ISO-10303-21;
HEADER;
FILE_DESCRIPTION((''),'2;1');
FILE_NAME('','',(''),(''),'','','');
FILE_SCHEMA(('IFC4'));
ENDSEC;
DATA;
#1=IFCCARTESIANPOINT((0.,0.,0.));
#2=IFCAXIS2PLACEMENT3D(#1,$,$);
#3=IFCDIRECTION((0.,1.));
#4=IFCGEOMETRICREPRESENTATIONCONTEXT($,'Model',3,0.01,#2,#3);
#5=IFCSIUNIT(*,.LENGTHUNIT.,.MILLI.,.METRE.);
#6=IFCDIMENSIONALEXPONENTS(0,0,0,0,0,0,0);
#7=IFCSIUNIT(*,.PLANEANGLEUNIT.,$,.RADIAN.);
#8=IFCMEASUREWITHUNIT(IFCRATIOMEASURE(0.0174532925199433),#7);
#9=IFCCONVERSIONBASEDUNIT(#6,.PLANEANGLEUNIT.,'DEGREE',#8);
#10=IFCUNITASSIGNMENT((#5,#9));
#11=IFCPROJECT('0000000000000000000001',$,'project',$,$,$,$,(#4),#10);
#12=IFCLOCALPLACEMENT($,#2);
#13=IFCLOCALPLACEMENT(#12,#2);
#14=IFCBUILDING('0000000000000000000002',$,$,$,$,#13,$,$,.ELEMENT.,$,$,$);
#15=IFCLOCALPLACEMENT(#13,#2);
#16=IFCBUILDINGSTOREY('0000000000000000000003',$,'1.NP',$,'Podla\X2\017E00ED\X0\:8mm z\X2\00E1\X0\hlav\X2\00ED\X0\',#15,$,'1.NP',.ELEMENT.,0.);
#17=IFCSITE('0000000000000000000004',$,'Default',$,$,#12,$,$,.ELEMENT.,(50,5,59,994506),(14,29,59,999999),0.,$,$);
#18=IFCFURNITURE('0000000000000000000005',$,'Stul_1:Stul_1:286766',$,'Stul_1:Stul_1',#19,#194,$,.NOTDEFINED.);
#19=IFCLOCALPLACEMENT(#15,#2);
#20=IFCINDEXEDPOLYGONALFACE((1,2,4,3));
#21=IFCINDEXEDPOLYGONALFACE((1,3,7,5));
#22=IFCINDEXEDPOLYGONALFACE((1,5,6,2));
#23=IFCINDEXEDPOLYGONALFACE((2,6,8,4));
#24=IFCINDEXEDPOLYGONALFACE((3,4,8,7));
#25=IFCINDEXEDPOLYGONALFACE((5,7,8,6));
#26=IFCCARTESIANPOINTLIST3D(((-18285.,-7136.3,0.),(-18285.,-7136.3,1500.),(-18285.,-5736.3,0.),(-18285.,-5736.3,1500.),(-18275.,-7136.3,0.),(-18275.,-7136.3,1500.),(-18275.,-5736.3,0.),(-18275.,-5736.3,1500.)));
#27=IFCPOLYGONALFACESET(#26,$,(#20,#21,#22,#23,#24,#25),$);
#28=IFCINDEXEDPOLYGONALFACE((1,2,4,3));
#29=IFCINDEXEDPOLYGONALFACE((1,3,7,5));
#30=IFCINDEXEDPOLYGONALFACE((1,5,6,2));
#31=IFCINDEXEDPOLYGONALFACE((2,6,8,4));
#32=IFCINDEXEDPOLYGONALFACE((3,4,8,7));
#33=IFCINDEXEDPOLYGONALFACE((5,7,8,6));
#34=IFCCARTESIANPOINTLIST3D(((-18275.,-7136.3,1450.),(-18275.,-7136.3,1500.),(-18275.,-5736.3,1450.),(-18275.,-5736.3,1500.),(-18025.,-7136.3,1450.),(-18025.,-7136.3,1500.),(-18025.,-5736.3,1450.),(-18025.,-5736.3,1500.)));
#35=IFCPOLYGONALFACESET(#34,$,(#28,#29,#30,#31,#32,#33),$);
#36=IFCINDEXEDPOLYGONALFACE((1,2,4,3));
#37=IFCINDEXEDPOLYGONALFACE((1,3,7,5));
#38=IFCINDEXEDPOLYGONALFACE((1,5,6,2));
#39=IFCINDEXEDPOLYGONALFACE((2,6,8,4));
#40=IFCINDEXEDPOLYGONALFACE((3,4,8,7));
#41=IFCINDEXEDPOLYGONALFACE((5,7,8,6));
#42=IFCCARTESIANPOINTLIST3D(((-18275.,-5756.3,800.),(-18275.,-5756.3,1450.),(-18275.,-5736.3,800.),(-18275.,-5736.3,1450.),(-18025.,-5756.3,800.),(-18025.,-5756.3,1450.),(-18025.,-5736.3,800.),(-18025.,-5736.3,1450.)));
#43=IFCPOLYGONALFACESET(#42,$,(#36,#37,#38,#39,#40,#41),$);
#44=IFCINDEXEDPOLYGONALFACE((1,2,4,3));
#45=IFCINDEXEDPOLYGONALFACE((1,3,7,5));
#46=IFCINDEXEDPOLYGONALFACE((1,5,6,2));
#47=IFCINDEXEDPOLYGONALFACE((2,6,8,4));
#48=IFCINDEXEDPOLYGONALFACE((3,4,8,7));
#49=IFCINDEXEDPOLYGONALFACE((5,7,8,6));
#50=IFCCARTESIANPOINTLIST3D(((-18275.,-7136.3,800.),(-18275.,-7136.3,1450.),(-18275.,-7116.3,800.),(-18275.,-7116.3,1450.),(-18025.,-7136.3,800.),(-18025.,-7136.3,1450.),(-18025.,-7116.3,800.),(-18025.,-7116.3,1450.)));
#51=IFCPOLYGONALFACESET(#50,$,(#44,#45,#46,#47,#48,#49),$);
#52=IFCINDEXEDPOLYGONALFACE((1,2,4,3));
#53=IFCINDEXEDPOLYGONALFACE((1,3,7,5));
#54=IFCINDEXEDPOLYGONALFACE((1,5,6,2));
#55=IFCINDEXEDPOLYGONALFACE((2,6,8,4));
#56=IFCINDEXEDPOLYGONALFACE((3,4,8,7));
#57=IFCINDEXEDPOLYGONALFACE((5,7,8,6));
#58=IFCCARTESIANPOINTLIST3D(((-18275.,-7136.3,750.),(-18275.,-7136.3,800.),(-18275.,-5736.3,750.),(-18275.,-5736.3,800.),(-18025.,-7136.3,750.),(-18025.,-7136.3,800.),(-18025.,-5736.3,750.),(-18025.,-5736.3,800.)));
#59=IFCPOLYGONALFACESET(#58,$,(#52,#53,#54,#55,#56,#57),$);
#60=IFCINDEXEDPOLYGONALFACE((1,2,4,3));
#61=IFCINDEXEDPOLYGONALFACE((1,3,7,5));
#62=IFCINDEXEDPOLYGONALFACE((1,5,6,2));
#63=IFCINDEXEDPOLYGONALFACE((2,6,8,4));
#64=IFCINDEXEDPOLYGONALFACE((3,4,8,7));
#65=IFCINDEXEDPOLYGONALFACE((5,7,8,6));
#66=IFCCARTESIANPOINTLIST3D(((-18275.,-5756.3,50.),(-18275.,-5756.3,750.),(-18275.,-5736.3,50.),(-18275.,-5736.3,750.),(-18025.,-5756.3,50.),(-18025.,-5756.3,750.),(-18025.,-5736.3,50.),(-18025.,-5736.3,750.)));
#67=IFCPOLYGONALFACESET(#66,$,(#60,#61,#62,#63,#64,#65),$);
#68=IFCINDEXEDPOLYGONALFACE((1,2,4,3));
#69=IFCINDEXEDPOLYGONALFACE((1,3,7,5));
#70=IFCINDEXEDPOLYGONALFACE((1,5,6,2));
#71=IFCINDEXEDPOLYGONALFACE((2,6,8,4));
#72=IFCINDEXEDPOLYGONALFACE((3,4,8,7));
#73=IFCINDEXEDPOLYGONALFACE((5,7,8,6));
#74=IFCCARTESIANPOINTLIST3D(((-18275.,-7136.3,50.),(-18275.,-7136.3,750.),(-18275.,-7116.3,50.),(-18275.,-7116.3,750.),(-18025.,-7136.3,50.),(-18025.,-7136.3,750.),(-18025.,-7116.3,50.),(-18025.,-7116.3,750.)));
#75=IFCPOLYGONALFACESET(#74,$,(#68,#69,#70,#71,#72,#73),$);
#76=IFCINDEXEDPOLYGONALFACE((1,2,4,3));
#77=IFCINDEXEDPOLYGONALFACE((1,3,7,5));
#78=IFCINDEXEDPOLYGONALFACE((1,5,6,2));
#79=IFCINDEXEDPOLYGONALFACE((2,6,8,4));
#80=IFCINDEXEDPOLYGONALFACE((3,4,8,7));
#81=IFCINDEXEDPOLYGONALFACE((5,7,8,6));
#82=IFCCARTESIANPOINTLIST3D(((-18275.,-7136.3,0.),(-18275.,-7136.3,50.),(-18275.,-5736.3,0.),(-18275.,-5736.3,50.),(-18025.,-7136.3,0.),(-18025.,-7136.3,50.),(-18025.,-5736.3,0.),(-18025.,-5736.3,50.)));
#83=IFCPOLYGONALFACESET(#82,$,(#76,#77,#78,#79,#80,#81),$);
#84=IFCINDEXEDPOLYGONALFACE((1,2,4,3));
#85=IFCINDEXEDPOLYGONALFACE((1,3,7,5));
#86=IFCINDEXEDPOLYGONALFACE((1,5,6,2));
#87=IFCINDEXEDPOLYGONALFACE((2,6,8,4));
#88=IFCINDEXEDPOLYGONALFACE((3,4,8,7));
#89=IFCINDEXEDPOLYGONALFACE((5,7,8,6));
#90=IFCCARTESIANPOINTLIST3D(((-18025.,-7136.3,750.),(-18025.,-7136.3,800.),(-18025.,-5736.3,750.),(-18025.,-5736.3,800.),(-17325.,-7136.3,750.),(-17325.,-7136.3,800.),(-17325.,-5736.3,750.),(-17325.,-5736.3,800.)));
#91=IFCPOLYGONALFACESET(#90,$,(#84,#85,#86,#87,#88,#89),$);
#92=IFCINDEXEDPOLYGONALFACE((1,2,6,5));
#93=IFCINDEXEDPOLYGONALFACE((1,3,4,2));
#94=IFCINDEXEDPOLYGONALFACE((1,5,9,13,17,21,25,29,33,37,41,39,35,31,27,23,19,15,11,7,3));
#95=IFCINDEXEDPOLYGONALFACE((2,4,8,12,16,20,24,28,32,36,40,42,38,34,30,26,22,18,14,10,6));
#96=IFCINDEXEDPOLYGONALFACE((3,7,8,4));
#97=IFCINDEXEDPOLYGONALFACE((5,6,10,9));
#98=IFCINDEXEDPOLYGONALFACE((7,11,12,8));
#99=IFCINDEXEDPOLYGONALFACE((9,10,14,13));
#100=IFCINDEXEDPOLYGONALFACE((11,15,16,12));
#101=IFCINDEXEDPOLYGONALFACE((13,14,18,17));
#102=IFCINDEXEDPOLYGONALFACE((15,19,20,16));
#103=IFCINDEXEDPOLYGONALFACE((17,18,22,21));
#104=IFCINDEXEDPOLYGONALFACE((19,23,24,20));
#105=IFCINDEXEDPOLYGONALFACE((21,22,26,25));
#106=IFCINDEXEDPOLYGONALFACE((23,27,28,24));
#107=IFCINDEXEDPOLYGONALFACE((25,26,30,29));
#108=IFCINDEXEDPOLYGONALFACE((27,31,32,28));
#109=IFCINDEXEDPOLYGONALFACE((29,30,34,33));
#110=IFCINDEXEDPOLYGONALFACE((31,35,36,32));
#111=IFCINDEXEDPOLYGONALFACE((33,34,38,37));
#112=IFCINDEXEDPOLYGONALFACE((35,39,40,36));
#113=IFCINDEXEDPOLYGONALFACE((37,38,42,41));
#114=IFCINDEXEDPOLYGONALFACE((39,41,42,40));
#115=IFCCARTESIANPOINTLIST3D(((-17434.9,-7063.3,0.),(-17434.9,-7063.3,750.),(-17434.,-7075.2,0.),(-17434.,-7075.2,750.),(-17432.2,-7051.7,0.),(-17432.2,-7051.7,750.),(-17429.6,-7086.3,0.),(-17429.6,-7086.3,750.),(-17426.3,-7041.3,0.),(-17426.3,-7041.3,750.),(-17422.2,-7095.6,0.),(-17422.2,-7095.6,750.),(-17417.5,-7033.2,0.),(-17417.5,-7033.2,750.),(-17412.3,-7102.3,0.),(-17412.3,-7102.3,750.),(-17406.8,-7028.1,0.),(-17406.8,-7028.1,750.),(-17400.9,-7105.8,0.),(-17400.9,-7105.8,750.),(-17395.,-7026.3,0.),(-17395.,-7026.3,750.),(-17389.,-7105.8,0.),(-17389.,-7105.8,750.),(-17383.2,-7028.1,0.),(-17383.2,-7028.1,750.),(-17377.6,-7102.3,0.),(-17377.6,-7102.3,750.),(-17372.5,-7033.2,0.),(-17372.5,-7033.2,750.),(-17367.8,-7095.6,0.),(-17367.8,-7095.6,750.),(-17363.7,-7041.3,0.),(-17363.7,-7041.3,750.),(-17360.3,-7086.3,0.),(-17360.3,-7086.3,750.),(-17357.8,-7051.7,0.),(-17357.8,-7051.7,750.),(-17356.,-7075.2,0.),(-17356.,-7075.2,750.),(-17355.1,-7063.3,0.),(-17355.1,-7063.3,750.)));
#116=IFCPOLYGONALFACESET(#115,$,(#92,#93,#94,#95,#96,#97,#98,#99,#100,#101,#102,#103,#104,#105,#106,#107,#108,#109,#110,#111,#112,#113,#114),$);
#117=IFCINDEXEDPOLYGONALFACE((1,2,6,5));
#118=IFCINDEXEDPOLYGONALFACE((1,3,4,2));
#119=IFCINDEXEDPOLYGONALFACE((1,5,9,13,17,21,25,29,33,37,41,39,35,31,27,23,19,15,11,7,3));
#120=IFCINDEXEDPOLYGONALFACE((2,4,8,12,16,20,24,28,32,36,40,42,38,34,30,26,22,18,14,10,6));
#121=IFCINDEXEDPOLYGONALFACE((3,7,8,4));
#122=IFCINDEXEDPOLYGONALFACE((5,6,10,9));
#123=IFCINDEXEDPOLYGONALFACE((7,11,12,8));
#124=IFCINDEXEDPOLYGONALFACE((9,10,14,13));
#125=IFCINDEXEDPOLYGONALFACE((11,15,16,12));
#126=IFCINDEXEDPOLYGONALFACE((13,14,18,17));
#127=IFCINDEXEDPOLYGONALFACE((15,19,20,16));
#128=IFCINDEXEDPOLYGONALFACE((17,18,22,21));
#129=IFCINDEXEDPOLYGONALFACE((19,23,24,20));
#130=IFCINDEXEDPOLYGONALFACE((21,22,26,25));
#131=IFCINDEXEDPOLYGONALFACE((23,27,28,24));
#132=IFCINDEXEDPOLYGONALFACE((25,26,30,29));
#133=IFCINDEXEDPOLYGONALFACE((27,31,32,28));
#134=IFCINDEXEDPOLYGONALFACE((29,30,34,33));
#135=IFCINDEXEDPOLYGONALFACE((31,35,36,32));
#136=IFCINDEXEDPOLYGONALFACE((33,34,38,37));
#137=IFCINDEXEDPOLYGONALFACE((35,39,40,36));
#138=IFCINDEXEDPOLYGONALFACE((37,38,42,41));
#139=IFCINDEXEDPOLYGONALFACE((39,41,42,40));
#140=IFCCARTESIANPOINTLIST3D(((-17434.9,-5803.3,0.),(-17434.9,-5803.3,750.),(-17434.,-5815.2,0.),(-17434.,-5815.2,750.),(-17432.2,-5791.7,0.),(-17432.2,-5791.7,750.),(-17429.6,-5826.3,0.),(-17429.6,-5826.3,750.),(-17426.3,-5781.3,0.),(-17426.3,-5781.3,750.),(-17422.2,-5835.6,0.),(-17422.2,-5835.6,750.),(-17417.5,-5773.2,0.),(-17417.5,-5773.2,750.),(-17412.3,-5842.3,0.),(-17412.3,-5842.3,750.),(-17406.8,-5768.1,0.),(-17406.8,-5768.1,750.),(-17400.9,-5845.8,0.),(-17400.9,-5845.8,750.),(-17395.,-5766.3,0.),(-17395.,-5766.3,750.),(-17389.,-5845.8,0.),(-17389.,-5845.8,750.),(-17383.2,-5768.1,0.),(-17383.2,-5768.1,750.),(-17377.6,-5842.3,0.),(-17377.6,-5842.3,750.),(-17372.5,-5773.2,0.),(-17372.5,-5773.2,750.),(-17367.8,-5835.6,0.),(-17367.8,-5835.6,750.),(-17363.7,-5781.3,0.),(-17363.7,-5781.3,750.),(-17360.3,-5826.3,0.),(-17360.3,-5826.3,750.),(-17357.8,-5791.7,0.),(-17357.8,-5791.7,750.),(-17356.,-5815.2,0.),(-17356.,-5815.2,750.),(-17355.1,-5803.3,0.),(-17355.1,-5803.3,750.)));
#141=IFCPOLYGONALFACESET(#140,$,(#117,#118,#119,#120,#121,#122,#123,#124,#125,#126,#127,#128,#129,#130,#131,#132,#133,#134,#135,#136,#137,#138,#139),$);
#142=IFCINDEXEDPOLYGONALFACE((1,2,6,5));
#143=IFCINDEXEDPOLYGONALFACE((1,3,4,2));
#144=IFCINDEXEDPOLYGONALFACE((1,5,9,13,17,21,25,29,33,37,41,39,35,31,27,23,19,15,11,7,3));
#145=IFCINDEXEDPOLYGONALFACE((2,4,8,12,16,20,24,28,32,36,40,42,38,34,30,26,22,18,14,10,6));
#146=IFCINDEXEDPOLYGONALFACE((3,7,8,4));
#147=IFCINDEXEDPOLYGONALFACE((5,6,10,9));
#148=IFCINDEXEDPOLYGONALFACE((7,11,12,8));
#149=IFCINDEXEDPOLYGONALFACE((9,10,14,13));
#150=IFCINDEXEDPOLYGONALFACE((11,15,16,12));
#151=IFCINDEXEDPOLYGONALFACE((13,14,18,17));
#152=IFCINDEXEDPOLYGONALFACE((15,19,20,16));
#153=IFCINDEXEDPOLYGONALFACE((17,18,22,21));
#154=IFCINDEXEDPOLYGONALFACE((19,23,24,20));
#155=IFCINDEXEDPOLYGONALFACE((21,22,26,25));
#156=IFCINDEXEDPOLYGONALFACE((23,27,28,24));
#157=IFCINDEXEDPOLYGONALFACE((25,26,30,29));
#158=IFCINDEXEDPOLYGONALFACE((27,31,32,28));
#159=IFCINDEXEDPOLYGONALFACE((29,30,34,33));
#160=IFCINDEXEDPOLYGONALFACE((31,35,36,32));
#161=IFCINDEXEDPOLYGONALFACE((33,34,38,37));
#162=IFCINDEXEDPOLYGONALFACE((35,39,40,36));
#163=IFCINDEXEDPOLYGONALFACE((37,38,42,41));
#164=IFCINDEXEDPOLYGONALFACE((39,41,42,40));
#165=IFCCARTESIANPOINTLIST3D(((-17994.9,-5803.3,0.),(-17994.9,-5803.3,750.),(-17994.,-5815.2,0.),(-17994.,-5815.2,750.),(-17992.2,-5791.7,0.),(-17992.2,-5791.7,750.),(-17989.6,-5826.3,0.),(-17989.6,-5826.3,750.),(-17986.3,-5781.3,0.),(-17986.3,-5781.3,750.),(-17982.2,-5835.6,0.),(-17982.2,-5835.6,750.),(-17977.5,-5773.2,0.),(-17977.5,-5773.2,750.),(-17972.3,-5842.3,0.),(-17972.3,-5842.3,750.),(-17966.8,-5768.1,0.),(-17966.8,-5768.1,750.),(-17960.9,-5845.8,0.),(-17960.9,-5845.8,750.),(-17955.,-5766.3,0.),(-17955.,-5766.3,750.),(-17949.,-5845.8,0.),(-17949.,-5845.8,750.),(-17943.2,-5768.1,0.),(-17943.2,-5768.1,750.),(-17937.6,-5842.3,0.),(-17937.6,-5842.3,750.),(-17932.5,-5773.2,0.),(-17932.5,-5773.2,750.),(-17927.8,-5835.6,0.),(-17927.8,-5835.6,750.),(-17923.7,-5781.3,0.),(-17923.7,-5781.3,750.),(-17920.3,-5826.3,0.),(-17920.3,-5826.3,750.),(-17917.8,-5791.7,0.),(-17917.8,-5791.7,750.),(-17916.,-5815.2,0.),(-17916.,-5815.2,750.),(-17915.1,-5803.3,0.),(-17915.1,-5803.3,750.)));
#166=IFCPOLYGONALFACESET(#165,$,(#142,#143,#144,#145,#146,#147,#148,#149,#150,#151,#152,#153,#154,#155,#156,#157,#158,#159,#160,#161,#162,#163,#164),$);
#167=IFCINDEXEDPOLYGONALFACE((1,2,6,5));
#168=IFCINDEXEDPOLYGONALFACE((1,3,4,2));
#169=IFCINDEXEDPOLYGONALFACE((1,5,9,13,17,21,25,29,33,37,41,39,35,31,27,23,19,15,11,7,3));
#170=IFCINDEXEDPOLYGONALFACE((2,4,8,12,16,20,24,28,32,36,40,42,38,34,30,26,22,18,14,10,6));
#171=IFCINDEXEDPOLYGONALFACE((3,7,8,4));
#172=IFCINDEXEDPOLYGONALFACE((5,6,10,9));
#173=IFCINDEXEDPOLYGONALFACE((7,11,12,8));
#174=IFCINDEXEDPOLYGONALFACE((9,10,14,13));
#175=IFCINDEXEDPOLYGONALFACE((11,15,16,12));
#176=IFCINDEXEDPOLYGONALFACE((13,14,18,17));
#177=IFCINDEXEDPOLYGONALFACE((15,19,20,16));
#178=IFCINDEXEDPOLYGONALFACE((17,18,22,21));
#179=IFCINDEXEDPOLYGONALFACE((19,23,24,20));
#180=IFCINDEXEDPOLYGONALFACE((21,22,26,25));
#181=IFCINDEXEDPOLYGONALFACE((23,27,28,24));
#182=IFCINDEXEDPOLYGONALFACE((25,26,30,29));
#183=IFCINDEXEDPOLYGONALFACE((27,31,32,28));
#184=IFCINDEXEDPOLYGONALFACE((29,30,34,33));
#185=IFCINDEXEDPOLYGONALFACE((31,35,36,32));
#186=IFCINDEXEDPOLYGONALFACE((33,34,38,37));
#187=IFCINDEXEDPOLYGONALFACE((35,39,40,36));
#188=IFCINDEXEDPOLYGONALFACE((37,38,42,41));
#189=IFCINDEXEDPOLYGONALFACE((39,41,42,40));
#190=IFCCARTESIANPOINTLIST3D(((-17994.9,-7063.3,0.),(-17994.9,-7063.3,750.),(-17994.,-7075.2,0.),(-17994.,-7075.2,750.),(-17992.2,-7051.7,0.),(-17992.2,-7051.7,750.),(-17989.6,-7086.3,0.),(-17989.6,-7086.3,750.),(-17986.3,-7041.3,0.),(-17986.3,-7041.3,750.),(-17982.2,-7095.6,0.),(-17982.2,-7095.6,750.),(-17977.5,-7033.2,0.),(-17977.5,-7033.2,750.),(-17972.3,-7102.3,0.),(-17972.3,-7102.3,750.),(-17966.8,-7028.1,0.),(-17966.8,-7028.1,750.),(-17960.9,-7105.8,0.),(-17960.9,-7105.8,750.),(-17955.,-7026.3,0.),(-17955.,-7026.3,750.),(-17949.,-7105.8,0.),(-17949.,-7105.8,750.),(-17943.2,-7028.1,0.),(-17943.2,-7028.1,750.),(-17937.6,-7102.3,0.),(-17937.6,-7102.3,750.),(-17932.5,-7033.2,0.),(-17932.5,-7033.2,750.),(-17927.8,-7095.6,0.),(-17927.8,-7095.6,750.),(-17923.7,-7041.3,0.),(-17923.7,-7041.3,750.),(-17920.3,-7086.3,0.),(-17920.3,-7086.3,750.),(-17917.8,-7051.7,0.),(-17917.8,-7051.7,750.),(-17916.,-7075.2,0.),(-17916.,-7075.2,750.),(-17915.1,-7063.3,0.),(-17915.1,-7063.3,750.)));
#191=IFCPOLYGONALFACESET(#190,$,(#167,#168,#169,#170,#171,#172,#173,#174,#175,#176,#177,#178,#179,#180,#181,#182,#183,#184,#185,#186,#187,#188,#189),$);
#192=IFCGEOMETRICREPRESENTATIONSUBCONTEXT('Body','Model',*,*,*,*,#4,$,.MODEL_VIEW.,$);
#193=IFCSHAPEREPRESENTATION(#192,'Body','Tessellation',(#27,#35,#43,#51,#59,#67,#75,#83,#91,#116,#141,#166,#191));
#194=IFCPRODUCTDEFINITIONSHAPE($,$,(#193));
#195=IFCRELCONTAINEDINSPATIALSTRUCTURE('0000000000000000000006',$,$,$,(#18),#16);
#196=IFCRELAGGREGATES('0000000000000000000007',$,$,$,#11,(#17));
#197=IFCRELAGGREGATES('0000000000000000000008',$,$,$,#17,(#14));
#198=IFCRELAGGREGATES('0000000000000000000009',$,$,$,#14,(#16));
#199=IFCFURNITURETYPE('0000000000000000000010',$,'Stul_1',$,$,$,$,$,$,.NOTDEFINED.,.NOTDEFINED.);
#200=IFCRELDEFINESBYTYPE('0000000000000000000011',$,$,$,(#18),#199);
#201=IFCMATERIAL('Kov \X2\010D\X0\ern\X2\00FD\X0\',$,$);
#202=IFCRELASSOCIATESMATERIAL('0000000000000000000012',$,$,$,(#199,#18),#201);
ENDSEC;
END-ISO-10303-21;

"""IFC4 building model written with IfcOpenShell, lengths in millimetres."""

from ifc_helpers import new_model, entity, si_unit, converted_unit, direction, frame, frame_2d, origin, origin_2d_with_axis, place, context, subcontext, project, spatial, rectangle, circle, extrude, source, transform, mapped, material, type_object, type_shapes, element, save


model = new_model("IFC4")

# Units and contexts
model_context = context("Model", 3, precision=0.01, world=origin(), true_north=direction((0.0, 1.0)))
body_context = subcontext(model_context, "Body", "Model", "MODEL_VIEW")
ifc_project = project(units=[si_unit("LENGTHUNIT", "METRE", prefix="MILLI"), converted_unit("PLANEANGLEUNIT", "DEGREE", entity("IfcRatioMeasure", 0.0174532925199433), si_unit("PLANEANGLEUNIT", "RADIAN"), dimensions=[0, 0, 0, 0, 0, 0, 0])], contexts=[model_context])

# Site, building, storey
site_placement = place(None, origin())
site = spatial("IfcSite", under=ifc_project, at=site_placement, Name="Default", CompositionType="ELEMENT", RefLatitude=(50, 5, 59, 994506), RefLongitude=(14, 29, 59, 999999), RefElevation=0.0)
building_placement = place(site_placement, origin())
building = spatial("IfcBuilding", under=site, at=building_placement, CompositionType="ELEMENT")
storey_placement = place(building_placement, origin())
storey = spatial("IfcBuildingStorey", under=building, at=storey_placement, Name="1.NP", ObjectType="Podlaží:8mm záhlaví", LongName="1.NP", CompositionType="ELEMENT", Elevation=0.0)

# Furniture
ifc_material_1 = material(Name="Kov černý")
furniture_type = type_object("IfcFurnitureType", Name="Stul_1", AssemblyPlace="NOTDEFINED", PredefinedType="NOTDEFINED", material=ifc_material_1)
shared_shape_1 = source(origin(), body_context, "Body", "SweptSolid", [
    extrude(rectangle(XDim=1400.0, YDim=10.0, at=origin_2d_with_axis()), frame((0.0, 605.0, 0.0), z_axis=(0.0, 0.0, 1.0), x_axis=(-1.0, 0.0, 0.0)), (0.0, 0.0, 1.0), 1500.0),
    extrude(rectangle(XDim=1400.0, YDim=250.0, at=frame_2d((0.0, 0.0), x_axis=(1.0, 0.0))), frame((0.0, 475.0, 1450.0), z_axis=(0.0, 0.0, 1.0), x_axis=(-1.0, 0.0, 0.0)), (0.0, 0.0, 1.0), 50.0),
    extrude(rectangle(XDim=20.0, YDim=250.0, at=origin_2d_with_axis()), frame((690.0, 475.0, 800.0), z_axis=(0.0, 0.0, 1.0), x_axis=(-1.0, 0.0, 0.0)), (0.0, 0.0, 1.0), 650.0),
    extrude(rectangle(XDim=20.0, YDim=250.0, at=frame_2d((0.0, 0.0), x_axis=(1.0, 0.0))), frame((-690.0, 475.0, 800.0), z_axis=(0.0, 0.0, 1.0), x_axis=(-1.0, 0.0, 0.0)), (0.0, 0.0, 1.0), 650.0),
    extrude(rectangle(XDim=1400.0, YDim=250.0, at=origin_2d_with_axis()), frame((0.0, 475.0, 750.0), z_axis=(0.0, 0.0, 1.0), x_axis=(-1.0, 0.0, 0.0)), (0.0, 0.0, 1.0), 50.0),
    extrude(rectangle(XDim=20.0, YDim=250.0, at=origin_2d_with_axis()), frame((690.0, 475.0, 50.0), z_axis=(0.0, 0.0, 1.0), x_axis=(-1.0, 0.0, 0.0)), (0.0, 0.0, 1.0), 700.0),
    extrude(rectangle(XDim=20.0, YDim=250.0, at=frame_2d((0.0, 0.0), x_axis=(1.0, 0.0))), frame((-690.0, 475.0, 50.0), z_axis=(0.0, 0.0, 1.0), x_axis=(-1.0, 0.0, 0.0)), (0.0, 0.0, 1.0), 700.0),
    extrude(rectangle(XDim=1400.0, YDim=250.0, at=origin_2d_with_axis()), frame((0.0, 475.0, 0.0), z_axis=(0.0, 0.0, 1.0), x_axis=(-1.0, 0.0, 0.0)), (0.0, 0.0, 1.0), 50.0),
    extrude(rectangle(XDim=1400.0, YDim=700.0, at=origin_2d_with_axis()), frame((0.0, 0.0, 750.0), z_axis=(0.0, 0.0, 1.0), x_axis=(-1.0, 0.0, 0.0)), (0.0, 0.0, 1.0), 50.0),
    extrude(circle(Radius=40.0, at=frame_2d((0.0, 0.0), x_axis=(1.0, 0.0))), frame((-630.0, -280.0, 0.0)), (0.0, 0.0, 1.0), 750.0),
    extrude(circle(Radius=40.0, at=frame_2d((0.0, 0.0), x_axis=(1.0, 0.0))), frame((630.0, -280.0, 0.0)), (0.0, 0.0, 1.0), 750.0),
    extrude(circle(Radius=40.0, at=frame_2d((0.0, 0.0), x_axis=(1.0, 0.0))), frame((630.0, 280.0, 0.0)), (0.0, 0.0, 1.0), 750.0),
    extrude(circle(Radius=40.0, at=frame_2d((0.0, 0.0), x_axis=(1.0, 0.0))), frame((-630.0, 280.0, 0.0)), (0.0, 0.0, 1.0), 750.0),
])
type_shapes(furniture_type, [shared_shape_1])
for number, where, z_axis, x_axis, name in (
    (1, (-17675.0, -6436.3, 0.0), (0.0, 0.0, 1.0), (0.0, 1.0, 0.0), "Stul_1:Stul_1:286766"),
):
    element("IfcFurniture", number, at=place(storey_placement, frame(where, z_axis=z_axis, x_axis=x_axis)), inside=storey, type_object=furniture_type, material=ifc_material_1, Name=name, ObjectType="Stul_1:Stul_1", PredefinedType="NOTDEFINED", context=body_context, shape_type="MappedRepresentation", body=[
        mapped(shared_shape_1, transform((0.0, 0.0, 0.0), scale=1.0)),
    ])

save(model, "model.ifc")
